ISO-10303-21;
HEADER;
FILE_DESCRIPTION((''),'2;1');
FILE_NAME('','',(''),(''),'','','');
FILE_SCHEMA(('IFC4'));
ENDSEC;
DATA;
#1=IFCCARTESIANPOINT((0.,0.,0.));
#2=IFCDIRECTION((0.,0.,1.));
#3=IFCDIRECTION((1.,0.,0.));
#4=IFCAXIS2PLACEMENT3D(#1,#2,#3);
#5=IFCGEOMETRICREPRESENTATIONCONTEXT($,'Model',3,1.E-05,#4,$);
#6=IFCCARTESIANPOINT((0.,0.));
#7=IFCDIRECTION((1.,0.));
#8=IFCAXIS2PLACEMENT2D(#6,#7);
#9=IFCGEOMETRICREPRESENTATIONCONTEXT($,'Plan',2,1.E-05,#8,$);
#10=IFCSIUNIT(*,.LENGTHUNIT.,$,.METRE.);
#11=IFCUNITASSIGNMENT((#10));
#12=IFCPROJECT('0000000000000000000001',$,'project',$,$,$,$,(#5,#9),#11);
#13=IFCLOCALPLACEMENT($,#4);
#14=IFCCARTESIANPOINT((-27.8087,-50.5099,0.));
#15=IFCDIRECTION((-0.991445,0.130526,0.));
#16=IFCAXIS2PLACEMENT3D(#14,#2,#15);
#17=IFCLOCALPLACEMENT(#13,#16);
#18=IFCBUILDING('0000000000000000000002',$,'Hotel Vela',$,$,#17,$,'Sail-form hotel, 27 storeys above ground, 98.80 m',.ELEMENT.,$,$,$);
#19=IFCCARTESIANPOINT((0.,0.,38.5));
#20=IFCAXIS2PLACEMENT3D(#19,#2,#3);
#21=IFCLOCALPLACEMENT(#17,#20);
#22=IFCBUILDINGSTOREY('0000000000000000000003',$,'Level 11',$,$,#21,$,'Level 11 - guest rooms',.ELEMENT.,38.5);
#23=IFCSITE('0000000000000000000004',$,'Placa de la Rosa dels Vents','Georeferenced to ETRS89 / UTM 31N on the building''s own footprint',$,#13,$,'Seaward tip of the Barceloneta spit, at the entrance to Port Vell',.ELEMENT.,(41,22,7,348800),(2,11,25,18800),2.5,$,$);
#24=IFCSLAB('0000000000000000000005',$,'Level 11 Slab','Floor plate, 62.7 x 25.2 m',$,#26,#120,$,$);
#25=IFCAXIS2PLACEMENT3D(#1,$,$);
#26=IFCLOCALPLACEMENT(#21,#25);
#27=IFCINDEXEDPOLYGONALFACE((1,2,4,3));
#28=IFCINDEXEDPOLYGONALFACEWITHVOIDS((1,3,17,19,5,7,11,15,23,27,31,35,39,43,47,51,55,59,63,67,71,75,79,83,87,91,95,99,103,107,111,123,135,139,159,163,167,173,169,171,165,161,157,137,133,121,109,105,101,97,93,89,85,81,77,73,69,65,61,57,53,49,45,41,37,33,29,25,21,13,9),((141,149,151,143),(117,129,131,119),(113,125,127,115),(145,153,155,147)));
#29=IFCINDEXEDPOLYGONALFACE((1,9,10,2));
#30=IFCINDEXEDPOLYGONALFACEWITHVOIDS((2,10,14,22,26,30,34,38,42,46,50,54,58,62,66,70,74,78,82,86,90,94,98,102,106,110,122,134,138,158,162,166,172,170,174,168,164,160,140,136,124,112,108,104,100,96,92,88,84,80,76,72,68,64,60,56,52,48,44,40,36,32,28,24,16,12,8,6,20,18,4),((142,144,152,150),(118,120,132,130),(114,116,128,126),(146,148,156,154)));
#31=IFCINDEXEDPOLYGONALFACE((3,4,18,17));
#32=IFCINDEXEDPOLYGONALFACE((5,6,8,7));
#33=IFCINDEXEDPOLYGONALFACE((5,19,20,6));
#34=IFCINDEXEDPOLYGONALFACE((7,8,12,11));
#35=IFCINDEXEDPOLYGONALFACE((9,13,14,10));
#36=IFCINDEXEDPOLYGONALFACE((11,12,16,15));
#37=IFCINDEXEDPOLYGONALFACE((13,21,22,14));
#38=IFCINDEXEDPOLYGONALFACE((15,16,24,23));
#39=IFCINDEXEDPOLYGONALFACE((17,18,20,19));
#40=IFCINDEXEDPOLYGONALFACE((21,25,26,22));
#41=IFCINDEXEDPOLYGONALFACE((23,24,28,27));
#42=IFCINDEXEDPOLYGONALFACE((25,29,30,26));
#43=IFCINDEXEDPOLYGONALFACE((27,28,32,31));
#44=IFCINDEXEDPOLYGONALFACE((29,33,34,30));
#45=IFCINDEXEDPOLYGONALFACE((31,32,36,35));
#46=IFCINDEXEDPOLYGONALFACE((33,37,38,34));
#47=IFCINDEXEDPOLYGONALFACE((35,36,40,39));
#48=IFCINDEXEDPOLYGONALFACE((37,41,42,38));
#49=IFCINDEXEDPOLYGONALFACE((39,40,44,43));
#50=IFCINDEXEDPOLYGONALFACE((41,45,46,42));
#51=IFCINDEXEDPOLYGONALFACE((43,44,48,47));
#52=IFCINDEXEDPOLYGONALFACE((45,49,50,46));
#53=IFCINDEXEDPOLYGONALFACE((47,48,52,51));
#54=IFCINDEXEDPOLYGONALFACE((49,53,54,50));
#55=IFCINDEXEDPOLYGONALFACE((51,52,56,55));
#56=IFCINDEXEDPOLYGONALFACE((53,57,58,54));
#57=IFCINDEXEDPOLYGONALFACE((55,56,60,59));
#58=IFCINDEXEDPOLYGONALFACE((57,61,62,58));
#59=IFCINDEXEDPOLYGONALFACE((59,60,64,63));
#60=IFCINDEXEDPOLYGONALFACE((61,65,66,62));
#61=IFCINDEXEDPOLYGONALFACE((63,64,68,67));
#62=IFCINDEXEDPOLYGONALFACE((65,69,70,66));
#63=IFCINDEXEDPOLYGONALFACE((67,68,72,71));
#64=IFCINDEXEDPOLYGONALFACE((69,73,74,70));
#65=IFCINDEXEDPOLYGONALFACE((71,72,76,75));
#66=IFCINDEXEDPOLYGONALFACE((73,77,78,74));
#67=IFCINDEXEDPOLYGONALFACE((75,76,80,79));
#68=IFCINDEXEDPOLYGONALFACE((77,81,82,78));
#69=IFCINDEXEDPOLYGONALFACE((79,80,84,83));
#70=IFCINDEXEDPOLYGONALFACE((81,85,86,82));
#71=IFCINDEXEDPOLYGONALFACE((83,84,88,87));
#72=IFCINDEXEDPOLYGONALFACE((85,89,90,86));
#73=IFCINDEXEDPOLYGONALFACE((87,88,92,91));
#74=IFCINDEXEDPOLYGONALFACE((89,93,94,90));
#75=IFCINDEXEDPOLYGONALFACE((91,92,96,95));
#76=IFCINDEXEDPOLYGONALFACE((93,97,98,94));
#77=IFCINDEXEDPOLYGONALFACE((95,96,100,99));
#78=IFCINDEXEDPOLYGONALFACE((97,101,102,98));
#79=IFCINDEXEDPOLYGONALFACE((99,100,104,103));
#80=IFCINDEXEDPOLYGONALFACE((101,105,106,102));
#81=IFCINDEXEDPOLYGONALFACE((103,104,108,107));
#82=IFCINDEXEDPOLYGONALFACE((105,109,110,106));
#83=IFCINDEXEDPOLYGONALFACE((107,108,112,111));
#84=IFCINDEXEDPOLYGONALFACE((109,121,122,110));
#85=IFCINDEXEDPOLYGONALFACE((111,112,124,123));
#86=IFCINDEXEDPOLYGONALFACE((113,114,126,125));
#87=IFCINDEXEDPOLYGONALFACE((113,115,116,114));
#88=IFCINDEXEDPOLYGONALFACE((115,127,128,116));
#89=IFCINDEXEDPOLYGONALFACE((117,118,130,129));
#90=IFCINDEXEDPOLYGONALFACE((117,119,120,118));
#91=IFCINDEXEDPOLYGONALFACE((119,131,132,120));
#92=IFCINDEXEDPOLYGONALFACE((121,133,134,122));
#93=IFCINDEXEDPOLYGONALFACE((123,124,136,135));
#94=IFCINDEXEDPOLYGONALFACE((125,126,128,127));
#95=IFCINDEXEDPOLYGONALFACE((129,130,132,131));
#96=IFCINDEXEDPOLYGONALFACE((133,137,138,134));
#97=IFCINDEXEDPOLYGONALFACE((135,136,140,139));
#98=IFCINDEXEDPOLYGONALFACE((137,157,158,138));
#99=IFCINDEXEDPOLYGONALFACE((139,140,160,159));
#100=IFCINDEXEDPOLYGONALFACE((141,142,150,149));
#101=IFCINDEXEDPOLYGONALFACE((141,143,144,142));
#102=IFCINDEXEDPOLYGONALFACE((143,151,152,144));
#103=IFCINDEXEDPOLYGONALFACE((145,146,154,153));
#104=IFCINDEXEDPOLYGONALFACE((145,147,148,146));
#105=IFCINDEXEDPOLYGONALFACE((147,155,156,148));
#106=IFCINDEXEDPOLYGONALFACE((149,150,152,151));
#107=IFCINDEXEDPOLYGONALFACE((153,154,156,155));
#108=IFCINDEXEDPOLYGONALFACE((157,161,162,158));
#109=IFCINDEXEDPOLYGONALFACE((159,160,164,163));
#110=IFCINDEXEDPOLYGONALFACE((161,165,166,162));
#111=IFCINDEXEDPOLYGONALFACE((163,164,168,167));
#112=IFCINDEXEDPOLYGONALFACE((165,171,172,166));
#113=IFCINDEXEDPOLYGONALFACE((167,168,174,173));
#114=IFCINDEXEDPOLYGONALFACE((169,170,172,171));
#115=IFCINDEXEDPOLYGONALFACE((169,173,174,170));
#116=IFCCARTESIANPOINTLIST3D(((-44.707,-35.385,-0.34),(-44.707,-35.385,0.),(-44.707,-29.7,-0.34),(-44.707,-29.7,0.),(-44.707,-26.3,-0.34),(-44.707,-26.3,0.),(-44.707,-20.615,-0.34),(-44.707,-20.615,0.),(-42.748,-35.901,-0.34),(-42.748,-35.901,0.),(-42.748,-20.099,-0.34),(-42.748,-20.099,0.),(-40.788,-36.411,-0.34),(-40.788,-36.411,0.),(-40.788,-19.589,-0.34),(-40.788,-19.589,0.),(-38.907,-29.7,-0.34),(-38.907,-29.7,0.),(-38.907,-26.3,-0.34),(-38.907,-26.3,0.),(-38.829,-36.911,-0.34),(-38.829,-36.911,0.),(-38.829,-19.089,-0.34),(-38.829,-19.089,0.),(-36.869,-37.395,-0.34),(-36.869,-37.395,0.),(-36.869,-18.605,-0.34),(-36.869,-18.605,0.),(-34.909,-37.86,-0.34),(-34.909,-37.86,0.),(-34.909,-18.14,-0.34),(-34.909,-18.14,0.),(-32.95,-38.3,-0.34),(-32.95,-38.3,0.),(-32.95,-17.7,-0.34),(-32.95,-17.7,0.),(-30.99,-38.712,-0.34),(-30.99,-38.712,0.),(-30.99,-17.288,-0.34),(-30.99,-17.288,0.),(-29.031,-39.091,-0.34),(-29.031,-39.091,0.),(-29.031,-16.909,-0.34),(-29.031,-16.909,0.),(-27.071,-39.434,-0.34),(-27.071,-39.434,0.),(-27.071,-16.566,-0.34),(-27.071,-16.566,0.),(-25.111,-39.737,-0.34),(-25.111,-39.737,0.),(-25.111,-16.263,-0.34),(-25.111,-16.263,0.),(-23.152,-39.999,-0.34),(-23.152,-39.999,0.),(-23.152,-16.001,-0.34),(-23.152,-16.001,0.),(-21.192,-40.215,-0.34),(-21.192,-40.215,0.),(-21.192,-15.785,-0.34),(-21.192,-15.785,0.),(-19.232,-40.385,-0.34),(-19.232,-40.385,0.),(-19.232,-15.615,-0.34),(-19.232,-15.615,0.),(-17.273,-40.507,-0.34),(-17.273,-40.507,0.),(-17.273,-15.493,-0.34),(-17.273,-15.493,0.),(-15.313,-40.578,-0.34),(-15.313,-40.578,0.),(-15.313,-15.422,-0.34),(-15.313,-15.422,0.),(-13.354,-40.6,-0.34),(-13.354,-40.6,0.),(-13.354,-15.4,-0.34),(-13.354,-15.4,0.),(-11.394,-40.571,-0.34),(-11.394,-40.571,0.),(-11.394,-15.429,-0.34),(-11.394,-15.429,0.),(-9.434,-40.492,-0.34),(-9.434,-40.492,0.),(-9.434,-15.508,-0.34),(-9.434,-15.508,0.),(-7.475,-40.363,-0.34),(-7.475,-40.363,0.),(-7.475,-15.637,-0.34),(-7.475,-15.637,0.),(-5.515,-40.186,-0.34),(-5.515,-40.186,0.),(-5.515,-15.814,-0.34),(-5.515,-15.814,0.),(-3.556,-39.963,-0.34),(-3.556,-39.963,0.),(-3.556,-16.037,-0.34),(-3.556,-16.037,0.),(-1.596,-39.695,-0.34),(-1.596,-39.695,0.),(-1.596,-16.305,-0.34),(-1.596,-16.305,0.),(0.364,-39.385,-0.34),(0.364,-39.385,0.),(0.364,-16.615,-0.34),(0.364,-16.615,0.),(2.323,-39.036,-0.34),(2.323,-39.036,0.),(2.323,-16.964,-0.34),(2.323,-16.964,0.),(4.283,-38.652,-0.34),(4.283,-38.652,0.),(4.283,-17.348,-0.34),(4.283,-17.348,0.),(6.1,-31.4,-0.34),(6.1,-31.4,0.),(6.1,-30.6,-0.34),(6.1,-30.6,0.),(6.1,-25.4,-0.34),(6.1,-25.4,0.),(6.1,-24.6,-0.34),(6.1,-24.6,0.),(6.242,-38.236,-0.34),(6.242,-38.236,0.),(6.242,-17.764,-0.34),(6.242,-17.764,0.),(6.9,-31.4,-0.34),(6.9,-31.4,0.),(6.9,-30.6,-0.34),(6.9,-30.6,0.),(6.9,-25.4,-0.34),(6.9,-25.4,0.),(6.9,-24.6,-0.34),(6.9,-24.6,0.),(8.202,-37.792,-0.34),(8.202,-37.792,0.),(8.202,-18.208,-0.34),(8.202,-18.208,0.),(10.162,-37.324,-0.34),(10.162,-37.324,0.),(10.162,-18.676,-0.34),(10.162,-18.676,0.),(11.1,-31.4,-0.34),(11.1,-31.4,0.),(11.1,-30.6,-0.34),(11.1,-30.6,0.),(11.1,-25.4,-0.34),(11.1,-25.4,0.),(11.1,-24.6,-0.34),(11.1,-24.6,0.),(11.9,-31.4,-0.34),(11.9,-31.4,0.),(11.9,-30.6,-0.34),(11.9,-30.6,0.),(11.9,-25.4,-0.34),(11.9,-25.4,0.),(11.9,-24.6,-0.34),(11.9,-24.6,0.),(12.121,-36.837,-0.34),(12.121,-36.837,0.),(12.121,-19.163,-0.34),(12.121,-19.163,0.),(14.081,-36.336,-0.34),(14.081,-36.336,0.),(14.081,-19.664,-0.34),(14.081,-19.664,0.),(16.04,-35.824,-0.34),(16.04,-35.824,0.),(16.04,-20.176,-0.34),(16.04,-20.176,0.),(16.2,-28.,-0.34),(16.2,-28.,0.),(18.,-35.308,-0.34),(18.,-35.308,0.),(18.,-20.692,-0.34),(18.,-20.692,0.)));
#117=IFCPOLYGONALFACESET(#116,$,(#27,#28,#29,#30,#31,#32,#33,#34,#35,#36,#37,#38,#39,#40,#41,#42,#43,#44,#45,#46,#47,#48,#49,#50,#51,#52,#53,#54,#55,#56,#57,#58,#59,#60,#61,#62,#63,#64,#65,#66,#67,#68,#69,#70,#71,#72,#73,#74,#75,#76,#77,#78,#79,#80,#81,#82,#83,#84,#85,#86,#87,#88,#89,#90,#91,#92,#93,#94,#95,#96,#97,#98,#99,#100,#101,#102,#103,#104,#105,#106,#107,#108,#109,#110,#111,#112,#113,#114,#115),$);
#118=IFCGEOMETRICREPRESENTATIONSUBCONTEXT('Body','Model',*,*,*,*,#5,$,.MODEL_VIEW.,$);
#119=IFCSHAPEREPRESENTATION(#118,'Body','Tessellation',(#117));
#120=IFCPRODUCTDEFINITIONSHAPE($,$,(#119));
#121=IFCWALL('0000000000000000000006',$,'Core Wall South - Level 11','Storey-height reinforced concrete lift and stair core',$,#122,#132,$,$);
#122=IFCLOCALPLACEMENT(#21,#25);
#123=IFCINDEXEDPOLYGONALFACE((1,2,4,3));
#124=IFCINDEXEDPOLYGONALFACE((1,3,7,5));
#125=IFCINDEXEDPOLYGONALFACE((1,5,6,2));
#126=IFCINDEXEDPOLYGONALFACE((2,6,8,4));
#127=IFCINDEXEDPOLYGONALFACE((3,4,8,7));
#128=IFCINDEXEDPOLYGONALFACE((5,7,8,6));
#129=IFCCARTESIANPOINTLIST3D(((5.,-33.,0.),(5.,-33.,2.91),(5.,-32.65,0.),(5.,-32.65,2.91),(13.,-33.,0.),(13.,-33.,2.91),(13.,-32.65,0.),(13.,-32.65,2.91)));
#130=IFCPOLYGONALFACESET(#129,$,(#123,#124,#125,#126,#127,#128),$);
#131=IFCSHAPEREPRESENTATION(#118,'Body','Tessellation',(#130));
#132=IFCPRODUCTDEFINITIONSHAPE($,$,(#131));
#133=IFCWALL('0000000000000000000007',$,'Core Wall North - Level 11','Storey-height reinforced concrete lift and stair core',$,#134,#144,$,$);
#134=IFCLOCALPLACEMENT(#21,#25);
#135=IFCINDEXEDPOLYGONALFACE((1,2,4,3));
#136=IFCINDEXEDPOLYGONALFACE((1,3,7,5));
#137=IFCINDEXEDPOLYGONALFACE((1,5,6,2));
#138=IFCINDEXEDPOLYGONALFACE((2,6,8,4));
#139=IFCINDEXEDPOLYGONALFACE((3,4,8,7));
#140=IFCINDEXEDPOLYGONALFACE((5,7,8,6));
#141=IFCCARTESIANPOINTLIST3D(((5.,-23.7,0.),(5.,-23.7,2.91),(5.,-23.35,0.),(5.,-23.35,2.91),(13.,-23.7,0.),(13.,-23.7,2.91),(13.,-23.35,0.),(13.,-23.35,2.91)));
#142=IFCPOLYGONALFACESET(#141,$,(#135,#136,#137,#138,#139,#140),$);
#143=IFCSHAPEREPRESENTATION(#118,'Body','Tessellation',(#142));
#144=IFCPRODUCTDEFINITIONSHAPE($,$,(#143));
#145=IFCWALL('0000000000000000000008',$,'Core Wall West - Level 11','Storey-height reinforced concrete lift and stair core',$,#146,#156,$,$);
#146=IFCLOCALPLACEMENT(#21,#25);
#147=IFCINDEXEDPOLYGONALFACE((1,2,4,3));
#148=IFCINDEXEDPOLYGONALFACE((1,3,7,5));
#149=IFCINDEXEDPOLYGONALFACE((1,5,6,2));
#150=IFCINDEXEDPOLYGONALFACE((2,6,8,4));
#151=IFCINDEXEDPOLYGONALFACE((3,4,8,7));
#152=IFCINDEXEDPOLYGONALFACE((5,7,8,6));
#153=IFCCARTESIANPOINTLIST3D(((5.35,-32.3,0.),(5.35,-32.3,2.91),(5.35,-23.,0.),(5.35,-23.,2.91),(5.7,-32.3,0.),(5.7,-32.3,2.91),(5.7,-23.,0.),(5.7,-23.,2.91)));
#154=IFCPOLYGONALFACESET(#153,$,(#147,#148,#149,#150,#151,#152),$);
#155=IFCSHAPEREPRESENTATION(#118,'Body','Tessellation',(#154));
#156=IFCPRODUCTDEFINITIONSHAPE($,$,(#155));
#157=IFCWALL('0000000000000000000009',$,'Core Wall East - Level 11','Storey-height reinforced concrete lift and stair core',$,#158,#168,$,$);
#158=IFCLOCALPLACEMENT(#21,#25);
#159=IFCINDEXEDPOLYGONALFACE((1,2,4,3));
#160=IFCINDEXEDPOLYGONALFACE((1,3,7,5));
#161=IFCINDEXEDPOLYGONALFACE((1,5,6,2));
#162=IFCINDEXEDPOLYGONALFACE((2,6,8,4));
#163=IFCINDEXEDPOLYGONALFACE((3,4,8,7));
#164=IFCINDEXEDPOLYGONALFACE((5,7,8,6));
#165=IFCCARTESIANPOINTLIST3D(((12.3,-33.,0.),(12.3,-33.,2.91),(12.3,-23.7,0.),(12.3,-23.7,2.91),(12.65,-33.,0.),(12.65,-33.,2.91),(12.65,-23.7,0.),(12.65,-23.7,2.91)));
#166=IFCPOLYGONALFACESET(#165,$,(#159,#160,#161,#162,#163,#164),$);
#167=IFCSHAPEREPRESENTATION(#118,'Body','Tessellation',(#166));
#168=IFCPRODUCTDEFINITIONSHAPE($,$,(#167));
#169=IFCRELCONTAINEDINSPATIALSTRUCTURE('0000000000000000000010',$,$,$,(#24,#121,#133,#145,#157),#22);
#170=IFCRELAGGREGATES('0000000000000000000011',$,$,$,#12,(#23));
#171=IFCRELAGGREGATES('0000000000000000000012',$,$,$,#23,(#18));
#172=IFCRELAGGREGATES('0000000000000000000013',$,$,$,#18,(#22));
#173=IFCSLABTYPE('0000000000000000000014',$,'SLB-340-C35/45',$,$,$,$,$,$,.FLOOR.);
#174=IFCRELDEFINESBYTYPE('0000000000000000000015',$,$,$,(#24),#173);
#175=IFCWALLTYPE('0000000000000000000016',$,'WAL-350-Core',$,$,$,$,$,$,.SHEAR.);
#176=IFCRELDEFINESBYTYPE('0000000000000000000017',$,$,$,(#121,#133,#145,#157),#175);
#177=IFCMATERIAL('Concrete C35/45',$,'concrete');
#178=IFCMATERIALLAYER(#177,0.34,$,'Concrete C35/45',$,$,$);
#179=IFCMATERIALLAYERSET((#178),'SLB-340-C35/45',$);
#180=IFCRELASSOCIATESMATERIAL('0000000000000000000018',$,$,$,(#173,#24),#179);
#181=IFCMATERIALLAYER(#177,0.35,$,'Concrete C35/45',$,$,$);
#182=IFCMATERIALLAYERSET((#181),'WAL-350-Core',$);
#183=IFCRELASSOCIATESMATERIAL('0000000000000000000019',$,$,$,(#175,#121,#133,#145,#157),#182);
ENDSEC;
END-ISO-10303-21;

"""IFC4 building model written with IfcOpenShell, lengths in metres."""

from ifc_helpers import new_model, si_unit, frame, origin_with_axes, origin_2d_with_axis, place, context, subcontext, project, spatial, line, indexed_curve, outline, extrude, material, layer, layer_set, layer_usage, type_object, element, save


model = new_model("IFC4")

# Units and contexts
model_context = context("Model", 3, precision=1e-05, world=origin_with_axes())
plan_context = context("Plan", 2, precision=1e-05, world=origin_2d_with_axis())
body_context = subcontext(model_context, "Body", "Model", "MODEL_VIEW")
ifc_project = project(units=[si_unit("LENGTHUNIT", "METRE")], contexts=[model_context, plan_context])

# Site, building, storey
site_placement = place(None, origin_with_axes())
site = spatial("IfcSite", under=ifc_project, at=site_placement, Name="Placa de la Rosa dels Vents", Description="Georeferenced to ETRS89 / UTM 31N on the building's own footprint", LongName="Seaward tip of the Barceloneta spit, at the entrance to Port Vell", CompositionType="ELEMENT", RefLatitude=(41, 22, 7, 348800), RefLongitude=(2, 11, 25, 18800), RefElevation=2.5)
building_placement = place(site_placement, frame((-27.8087, -50.5099, 0.0), z_axis=(0.0, 0.0, 1.0), x_axis=(-0.991445, 0.130526, 0.0)))
building = spatial("IfcBuilding", under=site, at=building_placement, Name="Hotel Vela", LongName="Sail-form hotel, 27 storeys above ground, 98.80 m", CompositionType="ELEMENT")
storey_placement = place(building_placement, frame((0.0, 0.0, 38.5), z_axis=(0.0, 0.0, 1.0), x_axis=(1.0, 0.0, 0.0)))
storey = spatial("IfcBuildingStorey", under=building, at=storey_placement, Name="Level 11", LongName="Level 11 - guest rooms", CompositionType="ELEMENT", Elevation=38.5)

# Shared definitions
ifc_material = material(Name="Concrete C35/45", Category="concrete")

# Slab, openings
ifc_layer_1 = layer(ifc_material, 0.34, Name="Concrete C35/45")
ifc_layer_set_1 = layer_set([ifc_layer_1], Name="SLB-340-C35/45")
ifc_layer_usage_1 = layer_usage(ifc_layer_set_1, "AXIS3", "POSITIVE", 0.0)
slab_type = type_object("IfcSlabType", Name="SLB-340-C35/45", PredefinedType="FLOOR", material=ifc_layer_set_1)
slab_placement = place(storey_placement, frame((0.0, 0.0, -0.34), z_axis=(0.0, 0.0, 1.0), x_axis=(1.0, 0.0, 0.0)))
slab = element("IfcSlab", 1, at=slab_placement, inside=storey, type_object=slab_type, material=ifc_layer_usage_1, Name="Level 11 Slab", Description="Floor plate, 62.7 x 25.2 m", context=body_context, shape_type="SweptSolid", body=[
    extrude(outline(indexed_curve([(-44.707, -35.385), (-42.748, -35.901), (-40.788, -36.411), (-38.829, -36.911), (-36.869, -37.395), (-34.909, -37.86), (-32.95, -38.3), (-30.99, -38.712), (-29.031, -39.091), (-27.071, -39.434), (-25.111, -39.737), (-23.152, -39.999), (-21.192, -40.215), (-19.232, -40.385), (-17.273, -40.507), (-15.313, -40.578), (-13.354, -40.6), (-11.394, -40.571), (-9.434, -40.492), (-7.475, -40.363), (-5.515, -40.186), (-3.556, -39.963), (-1.596, -39.695), (0.364, -39.385), (2.323, -39.036), (4.283, -38.652), (6.242, -38.236), (8.202, -37.792), (10.162, -37.324), (12.121, -36.837), (14.081, -36.336), (16.04, -35.824), (18.0, -35.308), (16.2, -28.0), (18.0, -20.692), (16.04, -20.176), (14.081, -19.664), (12.121, -19.163), (10.162, -18.676), (8.202, -18.208), (6.242, -17.764), (4.283, -17.348), (2.323, -16.964), (0.364, -16.615), (-1.596, -16.305), (-3.556, -16.037), (-5.515, -15.814), (-7.475, -15.637), (-9.434, -15.508), (-11.394, -15.429), (-13.354, -15.4), (-15.313, -15.422), (-17.273, -15.493), (-19.232, -15.615), (-21.192, -15.785), (-23.152, -16.001), (-25.111, -16.263), (-27.071, -16.566), (-29.031, -16.909), (-30.99, -17.288), (-32.95, -17.7), (-34.909, -18.14), (-36.869, -18.605), (-38.829, -19.089), (-40.788, -19.589), (-42.748, -20.099), (-44.707, -20.615), (-44.707, -26.3), (-38.907, -26.3), (-38.907, -29.7), (-44.707, -29.7)], segments=[line(1, 2, 3, 4, 5, 6, 7, 8, 9, 10, 11, 12, 13, 14, 15, 16, 17, 18, 19, 20, 21, 22, 23, 24, 25, 26, 27, 28, 29, 30, 31, 32, 33, 34, 35, 36, 37, 38, 39, 40, 41, 42, 43, 44, 45, 46, 47, 48, 49, 50, 51, 52, 53, 54, 55, 56, 57, 58, 59, 60, 61, 62, 63, 64, 65, 66, 67, 68, 69, 70, 71, 1)])), origin_with_axes(), (0.0, 0.0, 1.0), 0.34),
])
opening_1_placement = place(slab_placement, frame((6.1, -31.4, -0.05), z_axis=(0.0, 0.0, 1.0), x_axis=(1.0, 0.0, 0.0)))
element("IfcOpeningElement", 2, at=opening_1_placement, cuts=slab, PredefinedType="OPENING", context=body_context, shape_type="SweptSolid", body=[
    extrude(outline(indexed_curve([(0.0, 0.0), (0.8, 0.0), (0.8, 0.8), (0.0, 0.8)], segments=[line(1, 2, 3, 4, 1)])), origin_with_axes(), (0.0, 0.0, 1.0), 0.44),
])
opening_2_placement = place(slab_placement, frame((6.1, -25.4, -0.05), z_axis=(0.0, 0.0, 1.0), x_axis=(1.0, 0.0, 0.0)))
element("IfcOpeningElement", 3, at=opening_2_placement, cuts=slab, PredefinedType="OPENING", context=body_context, shape_type="SweptSolid", body=[
    extrude(outline(indexed_curve([(0.0, 0.0), (0.8, 0.0), (0.8, 0.8), (0.0, 0.8)], segments=[line(1, 2, 3, 4, 1)])), origin_with_axes(), (0.0, 0.0, 1.0), 0.44),
])
opening_3_placement = place(slab_placement, frame((11.1, -31.4, -0.05), z_axis=(0.0, 0.0, 1.0), x_axis=(1.0, 0.0, 0.0)))
element("IfcOpeningElement", 4, at=opening_3_placement, cuts=slab, PredefinedType="OPENING", context=body_context, shape_type="SweptSolid", body=[
    extrude(outline(indexed_curve([(0.0, 0.0), (0.8, 0.0), (0.8, 0.8), (0.0, 0.8)], segments=[line(1, 2, 3, 4, 1)])), origin_with_axes(), (0.0, 0.0, 1.0), 0.44),
])
opening_4_placement = place(slab_placement, frame((11.1, -25.4, -0.05), z_axis=(0.0, 0.0, 1.0), x_axis=(1.0, 0.0, 0.0)))
element("IfcOpeningElement", 5, at=opening_4_placement, cuts=slab, PredefinedType="OPENING", context=body_context, shape_type="SweptSolid", body=[
    extrude(outline(indexed_curve([(0.0, 0.0), (0.8, 0.0), (0.8, 0.8), (0.0, 0.8)], segments=[line(1, 2, 3, 4, 1)])), origin_with_axes(), (0.0, 0.0, 1.0), 0.44),
])

# Walls
ifc_layer_2 = layer(ifc_material, 0.35, Name="Concrete C35/45")
ifc_layer_set_2 = layer_set([ifc_layer_2], Name="WAL-350-Core")
ifc_layer_usage_2 = layer_usage(ifc_layer_set_2, "AXIS2", "POSITIVE", 0.0)
wall_type = type_object("IfcWallType", Name="WAL-350-Core", PredefinedType="SHEAR", material=ifc_layer_set_2)
wall_1_placement = place(storey_placement, frame((5.0, -33.0, 0.0), z_axis=(0.0, 0.0, 1.0), x_axis=(1.0, 0.0, 0.0)))
element("IfcWall", 6, at=wall_1_placement, inside=storey, type_object=wall_type, material=ifc_layer_usage_2, Name="Core Wall South - Level 11", Description="Storey-height reinforced concrete lift and stair core", context=body_context, shape_type="SweptSolid", body=[
    extrude(outline(indexed_curve([(0.0, 0.0), (8.0, 0.0), (8.0, 0.35), (0.0, 0.35)], segments=[line(1, 2, 3, 4, 1)])), origin_with_axes(), (0.0, 0.0, 1.0), 2.91),
])
ifc_layer_usage_3 = layer_usage(ifc_layer_set_2, "AXIS2", "POSITIVE", 0.0)
wall_2_placement = place(storey_placement, frame((13.0, -23.35, 0.0), z_axis=(0.0, 0.0, 1.0), x_axis=(-1.0, 0.0, 0.0)))
element("IfcWall", 7, at=wall_2_placement, inside=storey, type_object=wall_type, material=ifc_layer_usage_3, Name="Core Wall North - Level 11", Description="Storey-height reinforced concrete lift and stair core", context=body_context, shape_type="SweptSolid", body=[
    extrude(outline(indexed_curve([(0.0, 0.0), (8.0, 0.0), (8.0, 0.35), (0.0, 0.35)], segments=[line(1, 2, 3, 4, 1)])), origin_with_axes(), (0.0, 0.0, 1.0), 2.91),
])
ifc_layer_usage_4 = layer_usage(ifc_layer_set_2, "AXIS2", "POSITIVE", 0.0)
wall_3_placement = place(storey_placement, frame((5.35, -23.0, 0.0), z_axis=(0.0, 0.0, 1.0), x_axis=(0.0, -1.0, 0.0)))
element("IfcWall", 8, at=wall_3_placement, inside=storey, type_object=wall_type, material=ifc_layer_usage_4, Name="Core Wall West - Level 11", Description="Storey-height reinforced concrete lift and stair core", context=body_context, shape_type="SweptSolid", body=[
    extrude(outline(indexed_curve([(0.0, 0.0), (9.3, 0.0), (9.3, 0.35), (0.0, 0.35)], segments=[line(1, 2, 3, 4, 1)])), origin_with_axes(), (0.0, 0.0, 1.0), 2.91),
])
ifc_layer_usage_5 = layer_usage(ifc_layer_set_2, "AXIS2", "POSITIVE", 0.0)
wall_4_placement = place(storey_placement, frame((12.65, -33.0, 0.0), z_axis=(0.0, 0.0, 1.0), x_axis=(0.0, 1.0, 0.0)))
element("IfcWall", 9, at=wall_4_placement, inside=storey, type_object=wall_type, material=ifc_layer_usage_5, Name="Core Wall East - Level 11", Description="Storey-height reinforced concrete lift and stair core", context=body_context, shape_type="SweptSolid", body=[
    extrude(outline(indexed_curve([(0.0, 0.0), (9.3, 0.0), (9.3, 0.35), (0.0, 0.35)], segments=[line(1, 2, 3, 4, 1)])), origin_with_axes(), (0.0, 0.0, 1.0), 2.91),
])

save(model, "model.ifc")
